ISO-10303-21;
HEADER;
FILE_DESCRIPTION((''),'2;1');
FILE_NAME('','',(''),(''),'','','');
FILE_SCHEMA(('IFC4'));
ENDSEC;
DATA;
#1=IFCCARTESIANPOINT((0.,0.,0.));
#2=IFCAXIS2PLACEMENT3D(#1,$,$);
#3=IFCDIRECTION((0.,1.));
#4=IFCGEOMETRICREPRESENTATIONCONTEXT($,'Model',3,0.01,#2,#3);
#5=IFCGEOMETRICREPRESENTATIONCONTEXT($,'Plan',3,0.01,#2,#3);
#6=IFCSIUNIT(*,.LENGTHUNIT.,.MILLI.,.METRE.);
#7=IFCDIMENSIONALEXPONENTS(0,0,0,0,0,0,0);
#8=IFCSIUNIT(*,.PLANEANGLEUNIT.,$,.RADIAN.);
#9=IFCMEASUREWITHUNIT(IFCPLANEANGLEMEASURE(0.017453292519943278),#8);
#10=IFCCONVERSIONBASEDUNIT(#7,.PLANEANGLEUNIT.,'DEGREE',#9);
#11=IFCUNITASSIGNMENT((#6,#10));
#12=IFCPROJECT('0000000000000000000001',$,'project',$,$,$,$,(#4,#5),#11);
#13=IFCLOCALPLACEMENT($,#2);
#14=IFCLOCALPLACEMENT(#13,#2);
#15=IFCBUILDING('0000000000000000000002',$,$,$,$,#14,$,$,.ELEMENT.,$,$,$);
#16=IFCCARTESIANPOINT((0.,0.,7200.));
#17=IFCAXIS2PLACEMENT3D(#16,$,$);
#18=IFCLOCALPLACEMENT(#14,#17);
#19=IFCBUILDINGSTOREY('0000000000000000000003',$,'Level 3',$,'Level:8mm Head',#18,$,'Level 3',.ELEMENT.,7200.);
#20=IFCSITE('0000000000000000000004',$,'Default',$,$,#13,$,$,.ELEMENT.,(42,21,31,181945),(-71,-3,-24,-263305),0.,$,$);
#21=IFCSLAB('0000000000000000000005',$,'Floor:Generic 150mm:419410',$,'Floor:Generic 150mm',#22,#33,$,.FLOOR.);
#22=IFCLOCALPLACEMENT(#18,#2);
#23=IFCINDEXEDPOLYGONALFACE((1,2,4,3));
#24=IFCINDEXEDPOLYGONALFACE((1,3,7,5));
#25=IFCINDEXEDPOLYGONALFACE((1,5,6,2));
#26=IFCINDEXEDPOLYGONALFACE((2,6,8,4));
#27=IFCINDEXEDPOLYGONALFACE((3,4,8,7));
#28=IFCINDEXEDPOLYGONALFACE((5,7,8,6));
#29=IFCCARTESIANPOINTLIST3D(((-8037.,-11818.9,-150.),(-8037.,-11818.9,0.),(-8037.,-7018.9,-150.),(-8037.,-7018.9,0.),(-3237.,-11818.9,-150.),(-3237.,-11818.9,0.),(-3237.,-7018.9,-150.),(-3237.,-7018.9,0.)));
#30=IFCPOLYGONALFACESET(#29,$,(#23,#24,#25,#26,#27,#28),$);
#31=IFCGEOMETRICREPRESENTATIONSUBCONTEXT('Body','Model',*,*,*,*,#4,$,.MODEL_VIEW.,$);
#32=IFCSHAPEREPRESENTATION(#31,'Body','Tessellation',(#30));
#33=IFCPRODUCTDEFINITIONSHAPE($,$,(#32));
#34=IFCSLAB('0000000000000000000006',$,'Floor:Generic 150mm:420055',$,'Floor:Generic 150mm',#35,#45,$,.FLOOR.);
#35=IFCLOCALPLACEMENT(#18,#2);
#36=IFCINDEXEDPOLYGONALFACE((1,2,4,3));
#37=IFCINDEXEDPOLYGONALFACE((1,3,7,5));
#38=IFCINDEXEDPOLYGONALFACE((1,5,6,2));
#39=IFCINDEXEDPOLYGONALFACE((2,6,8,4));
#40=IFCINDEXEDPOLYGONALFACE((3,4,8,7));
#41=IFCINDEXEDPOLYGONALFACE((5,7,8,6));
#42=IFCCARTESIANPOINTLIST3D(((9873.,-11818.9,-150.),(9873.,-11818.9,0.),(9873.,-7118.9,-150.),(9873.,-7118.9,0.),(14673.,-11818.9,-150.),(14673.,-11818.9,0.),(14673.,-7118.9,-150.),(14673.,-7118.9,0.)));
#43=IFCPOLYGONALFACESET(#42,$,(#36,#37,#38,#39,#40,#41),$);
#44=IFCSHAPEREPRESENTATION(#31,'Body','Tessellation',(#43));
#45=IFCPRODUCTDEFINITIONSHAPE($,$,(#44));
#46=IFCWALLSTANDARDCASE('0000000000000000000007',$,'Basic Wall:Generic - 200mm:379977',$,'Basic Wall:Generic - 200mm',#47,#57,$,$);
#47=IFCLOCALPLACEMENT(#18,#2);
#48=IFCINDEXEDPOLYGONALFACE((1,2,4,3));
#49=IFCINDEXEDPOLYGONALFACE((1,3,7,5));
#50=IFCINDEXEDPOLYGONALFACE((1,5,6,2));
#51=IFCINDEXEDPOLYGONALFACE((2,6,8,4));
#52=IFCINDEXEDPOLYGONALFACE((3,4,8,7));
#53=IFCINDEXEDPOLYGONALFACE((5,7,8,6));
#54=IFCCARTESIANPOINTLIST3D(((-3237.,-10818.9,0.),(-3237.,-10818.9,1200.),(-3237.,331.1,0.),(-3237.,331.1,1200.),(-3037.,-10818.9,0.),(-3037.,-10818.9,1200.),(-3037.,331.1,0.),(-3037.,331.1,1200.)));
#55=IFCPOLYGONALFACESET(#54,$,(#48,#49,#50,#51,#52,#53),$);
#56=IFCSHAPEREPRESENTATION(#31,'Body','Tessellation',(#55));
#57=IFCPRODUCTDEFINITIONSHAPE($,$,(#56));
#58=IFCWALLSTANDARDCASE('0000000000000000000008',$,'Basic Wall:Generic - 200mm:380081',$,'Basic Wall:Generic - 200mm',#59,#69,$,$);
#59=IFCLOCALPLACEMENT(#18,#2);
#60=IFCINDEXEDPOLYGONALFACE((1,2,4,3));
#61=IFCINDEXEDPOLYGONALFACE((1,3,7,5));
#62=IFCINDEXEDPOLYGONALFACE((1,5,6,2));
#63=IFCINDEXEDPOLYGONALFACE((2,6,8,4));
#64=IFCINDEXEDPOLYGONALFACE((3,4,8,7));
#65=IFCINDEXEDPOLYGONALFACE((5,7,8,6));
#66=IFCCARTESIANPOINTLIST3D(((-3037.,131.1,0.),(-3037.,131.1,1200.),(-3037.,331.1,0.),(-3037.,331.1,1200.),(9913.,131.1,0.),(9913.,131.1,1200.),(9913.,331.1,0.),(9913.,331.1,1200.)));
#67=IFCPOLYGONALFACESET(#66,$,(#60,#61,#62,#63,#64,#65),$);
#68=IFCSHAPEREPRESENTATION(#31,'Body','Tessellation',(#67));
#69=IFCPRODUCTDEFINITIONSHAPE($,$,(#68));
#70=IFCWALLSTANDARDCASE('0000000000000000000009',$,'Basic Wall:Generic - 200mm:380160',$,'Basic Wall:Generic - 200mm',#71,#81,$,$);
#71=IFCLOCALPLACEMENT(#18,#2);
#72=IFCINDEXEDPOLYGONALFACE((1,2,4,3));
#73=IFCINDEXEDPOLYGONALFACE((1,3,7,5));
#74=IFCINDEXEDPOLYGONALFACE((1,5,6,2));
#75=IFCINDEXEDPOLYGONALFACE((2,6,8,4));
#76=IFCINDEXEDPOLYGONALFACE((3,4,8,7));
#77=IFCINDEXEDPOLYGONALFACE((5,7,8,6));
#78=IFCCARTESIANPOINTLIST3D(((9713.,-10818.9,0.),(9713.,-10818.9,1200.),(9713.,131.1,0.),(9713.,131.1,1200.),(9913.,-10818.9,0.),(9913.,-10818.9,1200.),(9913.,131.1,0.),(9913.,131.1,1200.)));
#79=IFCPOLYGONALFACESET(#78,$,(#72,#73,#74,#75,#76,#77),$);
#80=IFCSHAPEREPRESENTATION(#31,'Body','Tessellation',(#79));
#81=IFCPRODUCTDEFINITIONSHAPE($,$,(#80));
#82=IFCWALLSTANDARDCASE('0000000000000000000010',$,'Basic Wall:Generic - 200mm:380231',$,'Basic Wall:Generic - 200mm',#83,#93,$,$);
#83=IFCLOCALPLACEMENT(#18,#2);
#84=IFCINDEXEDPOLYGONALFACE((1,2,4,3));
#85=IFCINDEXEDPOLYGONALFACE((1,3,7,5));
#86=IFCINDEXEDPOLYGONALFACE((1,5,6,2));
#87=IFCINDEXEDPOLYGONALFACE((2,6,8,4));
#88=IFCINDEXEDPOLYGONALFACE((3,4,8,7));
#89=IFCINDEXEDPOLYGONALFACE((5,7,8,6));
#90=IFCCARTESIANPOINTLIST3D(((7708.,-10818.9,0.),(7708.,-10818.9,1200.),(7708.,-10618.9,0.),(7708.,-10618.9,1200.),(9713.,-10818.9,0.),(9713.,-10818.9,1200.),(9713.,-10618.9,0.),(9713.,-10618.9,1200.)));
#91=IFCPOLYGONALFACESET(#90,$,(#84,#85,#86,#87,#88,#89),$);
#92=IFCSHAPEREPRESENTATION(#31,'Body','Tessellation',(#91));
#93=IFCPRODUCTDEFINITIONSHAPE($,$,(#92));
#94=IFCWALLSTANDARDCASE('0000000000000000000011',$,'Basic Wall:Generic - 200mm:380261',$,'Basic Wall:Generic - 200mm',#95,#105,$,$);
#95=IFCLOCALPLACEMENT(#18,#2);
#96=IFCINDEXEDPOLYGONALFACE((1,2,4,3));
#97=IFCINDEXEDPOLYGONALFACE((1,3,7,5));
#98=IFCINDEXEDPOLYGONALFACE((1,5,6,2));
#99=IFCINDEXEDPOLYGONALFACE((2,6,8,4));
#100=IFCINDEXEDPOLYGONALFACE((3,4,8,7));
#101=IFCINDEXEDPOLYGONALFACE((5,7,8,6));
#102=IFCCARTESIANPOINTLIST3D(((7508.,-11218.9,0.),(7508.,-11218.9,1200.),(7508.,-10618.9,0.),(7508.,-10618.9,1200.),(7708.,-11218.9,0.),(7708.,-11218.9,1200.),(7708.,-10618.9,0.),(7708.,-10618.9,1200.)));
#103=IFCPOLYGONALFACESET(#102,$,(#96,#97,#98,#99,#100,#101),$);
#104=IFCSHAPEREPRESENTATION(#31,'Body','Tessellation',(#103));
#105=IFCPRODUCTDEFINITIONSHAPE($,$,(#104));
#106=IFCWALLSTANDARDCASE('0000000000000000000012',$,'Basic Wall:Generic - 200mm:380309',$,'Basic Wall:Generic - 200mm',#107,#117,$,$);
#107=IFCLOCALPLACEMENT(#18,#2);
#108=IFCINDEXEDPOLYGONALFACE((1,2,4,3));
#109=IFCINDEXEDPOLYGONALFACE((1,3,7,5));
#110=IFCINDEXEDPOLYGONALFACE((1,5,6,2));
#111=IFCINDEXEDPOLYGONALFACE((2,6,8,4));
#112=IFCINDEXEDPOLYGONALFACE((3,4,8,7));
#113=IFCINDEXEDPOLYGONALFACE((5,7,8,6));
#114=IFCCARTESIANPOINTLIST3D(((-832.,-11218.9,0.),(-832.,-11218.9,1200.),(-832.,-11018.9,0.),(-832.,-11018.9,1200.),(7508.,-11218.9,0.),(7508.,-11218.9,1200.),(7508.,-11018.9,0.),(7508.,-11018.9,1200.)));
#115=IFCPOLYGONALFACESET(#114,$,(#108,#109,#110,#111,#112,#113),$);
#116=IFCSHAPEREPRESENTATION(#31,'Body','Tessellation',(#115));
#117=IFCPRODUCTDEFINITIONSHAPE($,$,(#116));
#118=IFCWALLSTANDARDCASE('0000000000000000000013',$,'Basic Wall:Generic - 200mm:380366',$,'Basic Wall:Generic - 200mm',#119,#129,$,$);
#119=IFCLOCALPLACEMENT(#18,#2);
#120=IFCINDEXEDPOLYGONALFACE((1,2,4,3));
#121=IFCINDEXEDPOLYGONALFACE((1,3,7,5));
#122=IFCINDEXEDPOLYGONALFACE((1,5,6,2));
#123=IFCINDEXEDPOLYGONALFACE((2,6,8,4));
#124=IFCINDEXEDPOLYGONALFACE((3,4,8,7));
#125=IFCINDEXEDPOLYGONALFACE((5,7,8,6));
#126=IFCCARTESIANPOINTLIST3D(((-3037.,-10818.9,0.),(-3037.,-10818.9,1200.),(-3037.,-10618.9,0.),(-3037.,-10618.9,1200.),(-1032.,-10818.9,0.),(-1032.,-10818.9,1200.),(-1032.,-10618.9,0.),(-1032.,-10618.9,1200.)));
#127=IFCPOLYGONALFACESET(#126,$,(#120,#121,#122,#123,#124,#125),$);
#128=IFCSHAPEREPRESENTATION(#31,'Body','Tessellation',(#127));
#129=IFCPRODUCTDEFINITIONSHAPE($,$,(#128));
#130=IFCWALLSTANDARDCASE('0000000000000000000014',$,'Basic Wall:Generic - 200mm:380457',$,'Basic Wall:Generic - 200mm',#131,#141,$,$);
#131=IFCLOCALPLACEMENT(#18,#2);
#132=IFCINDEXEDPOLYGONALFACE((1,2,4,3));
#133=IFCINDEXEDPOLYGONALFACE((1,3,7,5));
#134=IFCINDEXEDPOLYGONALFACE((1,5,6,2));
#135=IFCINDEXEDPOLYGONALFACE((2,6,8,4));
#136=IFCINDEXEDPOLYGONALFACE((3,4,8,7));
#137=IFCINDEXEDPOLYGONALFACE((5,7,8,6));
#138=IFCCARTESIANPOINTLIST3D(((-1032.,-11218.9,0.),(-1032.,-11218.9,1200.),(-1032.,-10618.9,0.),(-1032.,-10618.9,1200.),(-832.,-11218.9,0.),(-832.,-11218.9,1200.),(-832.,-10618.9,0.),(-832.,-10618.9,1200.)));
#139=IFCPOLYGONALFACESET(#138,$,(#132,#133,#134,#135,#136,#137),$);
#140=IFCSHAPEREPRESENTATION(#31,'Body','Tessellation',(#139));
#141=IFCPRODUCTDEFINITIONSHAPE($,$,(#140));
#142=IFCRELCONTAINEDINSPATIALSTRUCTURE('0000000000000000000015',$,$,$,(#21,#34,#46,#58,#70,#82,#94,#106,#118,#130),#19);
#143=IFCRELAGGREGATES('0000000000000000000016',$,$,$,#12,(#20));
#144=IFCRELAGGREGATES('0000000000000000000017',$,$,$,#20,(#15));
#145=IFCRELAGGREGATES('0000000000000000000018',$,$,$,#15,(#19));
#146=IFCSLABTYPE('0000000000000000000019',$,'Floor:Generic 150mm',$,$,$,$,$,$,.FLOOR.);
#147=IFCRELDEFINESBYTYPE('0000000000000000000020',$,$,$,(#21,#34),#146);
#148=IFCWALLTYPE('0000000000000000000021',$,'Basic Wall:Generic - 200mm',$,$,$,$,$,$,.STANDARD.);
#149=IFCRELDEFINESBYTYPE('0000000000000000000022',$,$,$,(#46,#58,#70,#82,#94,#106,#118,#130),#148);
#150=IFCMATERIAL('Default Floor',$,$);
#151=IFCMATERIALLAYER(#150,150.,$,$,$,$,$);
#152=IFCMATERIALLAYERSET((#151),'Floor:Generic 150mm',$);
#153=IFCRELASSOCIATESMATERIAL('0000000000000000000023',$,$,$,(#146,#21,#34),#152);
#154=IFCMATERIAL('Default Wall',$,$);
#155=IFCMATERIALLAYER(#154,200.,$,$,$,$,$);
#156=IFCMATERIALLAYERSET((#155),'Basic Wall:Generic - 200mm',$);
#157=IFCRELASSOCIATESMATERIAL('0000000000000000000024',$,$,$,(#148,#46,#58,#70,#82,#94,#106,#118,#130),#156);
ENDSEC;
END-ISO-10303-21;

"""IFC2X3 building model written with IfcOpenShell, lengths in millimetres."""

from ifc_helpers import new_model, entity, si_unit, converted_unit, direction, frame, frame_2d, origin, place, context, subcontext, project, spatial, rectangle, extrude, material, layer, layer_set, layer_usage, type_object, element, save


model = new_model("IFC2X3")

# Units and contexts
model_context = context("Model", 3, precision=0.01, world=origin(), true_north=direction((0.0, 1.0)))
plan_context = context("Plan", 3, precision=0.01, world=origin(), true_north=direction((0.0, 1.0)))
body_context = subcontext(model_context, "Body", "Model", "MODEL_VIEW")
ifc_project = project(units=[si_unit("LENGTHUNIT", "METRE", prefix="MILLI"), converted_unit("PLANEANGLEUNIT", "DEGREE", entity("IfcPlaneAngleMeasure", 0.017453292519943278), si_unit("PLANEANGLEUNIT", "RADIAN"), dimensions=[0, 0, 0, 0, 0, 0, 0])], contexts=[model_context, plan_context])

# Site, building, storey
site_placement = place(None, origin())
site = spatial("IfcSite", under=ifc_project, at=site_placement, Name="Default", CompositionType="ELEMENT", RefLatitude=(42, 21, 31, 181945), RefLongitude=(-71, -3, -24, -263305), RefElevation=0.0)
building_placement = place(site_placement, origin())
building = spatial("IfcBuilding", under=site, at=building_placement, CompositionType="ELEMENT")
storey_placement = place(building_placement, frame((0.0, 0.0, 7200.0)))
storey = spatial("IfcBuildingStorey", under=building, at=storey_placement, Name="Level 3", ObjectType="Level:8mm Head", LongName="Level 3", CompositionType="ELEMENT", Elevation=7200.0)

# Slabs
ifc_material_1 = material(Name="Default Floor")
ifc_layer_1 = layer(ifc_material_1, 150.0)
ifc_layer_set_1 = layer_set([ifc_layer_1], Name="Floor:Generic 150mm")
slab_type = type_object("IfcSlabType", Name="Floor:Generic 150mm", PredefinedType="FLOOR", material=ifc_layer_set_1)
ifc_layer_usage_1 = layer_usage(ifc_layer_set_1, "AXIS3", "POSITIVE", 0.0)
slab_1_placement = place(storey_placement, origin())
element("IfcSlab", 1, at=slab_1_placement, inside=storey, type_object=slab_type, material=ifc_layer_usage_1, Name="Floor:Generic 150mm:419410", ObjectType="Floor:Generic 150mm", PredefinedType="FLOOR", context=body_context, shape_type="SweptSolid", body=[
    extrude(rectangle(XDim=4800.0, YDim=4800.0, at=frame_2d((0.0, 0.0), x_axis=(1.0, 0.0))), frame((-5637.0, -9418.9, 0.0), z_axis=(0.0, 0.0, -1.0), x_axis=(0.0, 1.0, 0.0)), (0.0, 0.0, 1.0), 150.0),
])
ifc_layer_usage_2 = layer_usage(ifc_layer_set_1, "AXIS3", "POSITIVE", 0.0)
slab_2_placement = place(storey_placement, origin())
element("IfcSlab", 2, at=slab_2_placement, inside=storey, type_object=slab_type, material=ifc_layer_usage_2, Name="Floor:Generic 150mm:420055", ObjectType="Floor:Generic 150mm", PredefinedType="FLOOR", context=body_context, shape_type="SweptSolid", body=[
    extrude(rectangle(XDim=4700.0, YDim=4800.0, at=frame_2d((0.0, 0.0), x_axis=(1.0, 0.0))), frame((12273.0, -9468.9, 0.0), z_axis=(0.0, 0.0, -1.0), x_axis=(0.0, 1.0, 0.0)), (0.0, 0.0, 1.0), 150.0),
])

# Walls
ifc_material_2 = material(Name="Default Wall")
ifc_layer_2 = layer(ifc_material_2, 200.0)
ifc_layer_set_2 = layer_set([ifc_layer_2], Name="Basic Wall:Generic - 200mm")
ifc_layer_usage_3 = layer_usage(ifc_layer_set_2, "AXIS2", "NEGATIVE", 100.0)
wall_type = type_object("IfcWallType", Name="Basic Wall:Generic - 200mm", PredefinedType="STANDARD", material=ifc_layer_set_2)
wall_1_placement = place(storey_placement, frame((-3137.0, -10818.9, 0.0), z_axis=(0.0, 0.0, 1.0), x_axis=(0.0, 1.0, 0.0)))
element("IfcWallStandardCase", 3, at=wall_1_placement, inside=storey, type_object=wall_type, material=ifc_layer_usage_3, Name="Basic Wall:Generic - 200mm:379977", ObjectType="Basic Wall:Generic - 200mm", context=body_context, shape_type="SweptSolid", body=[
    extrude(rectangle(XDim=11150.0, YDim=200.0, at=frame_2d((5575.0, 0.0), x_axis=(-1.0, 0.0))), origin(), (0.0, 0.0, 1.0), 1200.0),
])
ifc_layer_usage_4 = layer_usage(ifc_layer_set_2, "AXIS2", "NEGATIVE", 100.0)
wall_2_placement = place(storey_placement, frame((-3037.0, 231.1, 0.0)))
element("IfcWallStandardCase", 4, at=wall_2_placement, inside=storey, type_object=wall_type, material=ifc_layer_usage_4, Name="Basic Wall:Generic - 200mm:380081", ObjectType="Basic Wall:Generic - 200mm", context=body_context, shape_type="SweptSolid", body=[
    extrude(rectangle(XDim=12950.0, YDim=200.0, at=frame_2d((6475.0, 0.0), x_axis=(-1.0, 0.0))), origin(), (0.0, 0.0, 1.0), 1200.0),
])
ifc_layer_usage_5 = layer_usage(ifc_layer_set_2, "AXIS2", "NEGATIVE", 100.0)
wall_3_placement = place(storey_placement, frame((9813.0, 131.1, 0.0), z_axis=(0.0, 0.0, 1.0), x_axis=(0.0, -1.0, 0.0)))
element("IfcWallStandardCase", 5, at=wall_3_placement, inside=storey, type_object=wall_type, material=ifc_layer_usage_5, Name="Basic Wall:Generic - 200mm:380160", ObjectType="Basic Wall:Generic - 200mm", context=body_context, shape_type="SweptSolid", body=[
    extrude(rectangle(XDim=10950.0, YDim=200.0, at=frame_2d((5475.0, 0.0), x_axis=(-1.0, 0.0))), origin(), (0.0, 0.0, 1.0), 1200.0),
])
ifc_layer_usage_6 = layer_usage(ifc_layer_set_2, "AXIS2", "NEGATIVE", 100.0)
wall_4_placement = place(storey_placement, frame((9713.0, -10718.9, 0.0), z_axis=(0.0, 0.0, 1.0), x_axis=(-1.0, 0.0, 0.0)))
element("IfcWallStandardCase", 6, at=wall_4_placement, inside=storey, type_object=wall_type, material=ifc_layer_usage_6, Name="Basic Wall:Generic - 200mm:380231", ObjectType="Basic Wall:Generic - 200mm", context=body_context, shape_type="SweptSolid", body=[
    extrude(rectangle(XDim=2005.0, YDim=200.0, at=frame_2d((1002.5, 0.0), x_axis=(-1.0, 0.0))), origin(), (0.0, 0.0, 1.0), 1200.0),
])
ifc_layer_usage_7 = layer_usage(ifc_layer_set_2, "AXIS2", "NEGATIVE", 100.0)
wall_5_placement = place(storey_placement, frame((7608.0, -10618.9, 0.0), z_axis=(0.0, 0.0, 1.0), x_axis=(0.0, -1.0, 0.0)))
element("IfcWallStandardCase", 7, at=wall_5_placement, inside=storey, type_object=wall_type, material=ifc_layer_usage_7, Name="Basic Wall:Generic - 200mm:380261", ObjectType="Basic Wall:Generic - 200mm", context=body_context, shape_type="SweptSolid", body=[
    extrude(rectangle(XDim=600.0, YDim=200.0, at=frame_2d((300.0, 0.0), x_axis=(-1.0, 0.0))), origin(), (0.0, 0.0, 1.0), 1200.0),
])
ifc_layer_usage_8 = layer_usage(ifc_layer_set_2, "AXIS2", "NEGATIVE", 100.0)
wall_6_placement = place(storey_placement, frame((7508.0, -11118.9, 0.0), z_axis=(0.0, 0.0, 1.0), x_axis=(-1.0, 0.0, 0.0)))
element("IfcWallStandardCase", 8, at=wall_6_placement, inside=storey, type_object=wall_type, material=ifc_layer_usage_8, Name="Basic Wall:Generic - 200mm:380309", ObjectType="Basic Wall:Generic - 200mm", context=body_context, shape_type="SweptSolid", body=[
    extrude(rectangle(XDim=8340.0, YDim=200.0, at=frame_2d((4170.0, 0.0), x_axis=(-1.0, 0.0))), origin(), (0.0, 0.0, 1.0), 1200.0),
])
ifc_layer_usage_9 = layer_usage(ifc_layer_set_2, "AXIS2", "NEGATIVE", 100.0)
wall_7_placement = place(storey_placement, frame((-1032.0, -10718.9, 0.0), z_axis=(0.0, 0.0, 1.0), x_axis=(-1.0, 0.0, 0.0)))
element("IfcWallStandardCase", 9, at=wall_7_placement, inside=storey, type_object=wall_type, material=ifc_layer_usage_9, Name="Basic Wall:Generic - 200mm:380366", ObjectType="Basic Wall:Generic - 200mm", context=body_context, shape_type="SweptSolid", body=[
    extrude(rectangle(XDim=2005.0, YDim=200.0, at=frame_2d((1002.5, 0.0), x_axis=(-1.0, 0.0))), origin(), (0.0, 0.0, 1.0), 1200.0),
])
ifc_layer_usage_10 = layer_usage(ifc_layer_set_2, "AXIS2", "NEGATIVE", 100.0)
wall_8_placement = place(storey_placement, frame((-932.0, -11218.9, 0.0), z_axis=(0.0, 0.0, 1.0), x_axis=(0.0, 1.0, 0.0)))
element("IfcWallStandardCase", 10, at=wall_8_placement, inside=storey, type_object=wall_type, material=ifc_layer_usage_10, Name="Basic Wall:Generic - 200mm:380457", ObjectType="Basic Wall:Generic - 200mm", context=body_context, shape_type="SweptSolid", body=[
    extrude(rectangle(XDim=600.0, YDim=200.0, at=frame_2d((300.0, 0.0), x_axis=(-1.0, 0.0))), origin(), (0.0, 0.0, 1.0), 1200.0),
])

save(model, "model.ifc")
